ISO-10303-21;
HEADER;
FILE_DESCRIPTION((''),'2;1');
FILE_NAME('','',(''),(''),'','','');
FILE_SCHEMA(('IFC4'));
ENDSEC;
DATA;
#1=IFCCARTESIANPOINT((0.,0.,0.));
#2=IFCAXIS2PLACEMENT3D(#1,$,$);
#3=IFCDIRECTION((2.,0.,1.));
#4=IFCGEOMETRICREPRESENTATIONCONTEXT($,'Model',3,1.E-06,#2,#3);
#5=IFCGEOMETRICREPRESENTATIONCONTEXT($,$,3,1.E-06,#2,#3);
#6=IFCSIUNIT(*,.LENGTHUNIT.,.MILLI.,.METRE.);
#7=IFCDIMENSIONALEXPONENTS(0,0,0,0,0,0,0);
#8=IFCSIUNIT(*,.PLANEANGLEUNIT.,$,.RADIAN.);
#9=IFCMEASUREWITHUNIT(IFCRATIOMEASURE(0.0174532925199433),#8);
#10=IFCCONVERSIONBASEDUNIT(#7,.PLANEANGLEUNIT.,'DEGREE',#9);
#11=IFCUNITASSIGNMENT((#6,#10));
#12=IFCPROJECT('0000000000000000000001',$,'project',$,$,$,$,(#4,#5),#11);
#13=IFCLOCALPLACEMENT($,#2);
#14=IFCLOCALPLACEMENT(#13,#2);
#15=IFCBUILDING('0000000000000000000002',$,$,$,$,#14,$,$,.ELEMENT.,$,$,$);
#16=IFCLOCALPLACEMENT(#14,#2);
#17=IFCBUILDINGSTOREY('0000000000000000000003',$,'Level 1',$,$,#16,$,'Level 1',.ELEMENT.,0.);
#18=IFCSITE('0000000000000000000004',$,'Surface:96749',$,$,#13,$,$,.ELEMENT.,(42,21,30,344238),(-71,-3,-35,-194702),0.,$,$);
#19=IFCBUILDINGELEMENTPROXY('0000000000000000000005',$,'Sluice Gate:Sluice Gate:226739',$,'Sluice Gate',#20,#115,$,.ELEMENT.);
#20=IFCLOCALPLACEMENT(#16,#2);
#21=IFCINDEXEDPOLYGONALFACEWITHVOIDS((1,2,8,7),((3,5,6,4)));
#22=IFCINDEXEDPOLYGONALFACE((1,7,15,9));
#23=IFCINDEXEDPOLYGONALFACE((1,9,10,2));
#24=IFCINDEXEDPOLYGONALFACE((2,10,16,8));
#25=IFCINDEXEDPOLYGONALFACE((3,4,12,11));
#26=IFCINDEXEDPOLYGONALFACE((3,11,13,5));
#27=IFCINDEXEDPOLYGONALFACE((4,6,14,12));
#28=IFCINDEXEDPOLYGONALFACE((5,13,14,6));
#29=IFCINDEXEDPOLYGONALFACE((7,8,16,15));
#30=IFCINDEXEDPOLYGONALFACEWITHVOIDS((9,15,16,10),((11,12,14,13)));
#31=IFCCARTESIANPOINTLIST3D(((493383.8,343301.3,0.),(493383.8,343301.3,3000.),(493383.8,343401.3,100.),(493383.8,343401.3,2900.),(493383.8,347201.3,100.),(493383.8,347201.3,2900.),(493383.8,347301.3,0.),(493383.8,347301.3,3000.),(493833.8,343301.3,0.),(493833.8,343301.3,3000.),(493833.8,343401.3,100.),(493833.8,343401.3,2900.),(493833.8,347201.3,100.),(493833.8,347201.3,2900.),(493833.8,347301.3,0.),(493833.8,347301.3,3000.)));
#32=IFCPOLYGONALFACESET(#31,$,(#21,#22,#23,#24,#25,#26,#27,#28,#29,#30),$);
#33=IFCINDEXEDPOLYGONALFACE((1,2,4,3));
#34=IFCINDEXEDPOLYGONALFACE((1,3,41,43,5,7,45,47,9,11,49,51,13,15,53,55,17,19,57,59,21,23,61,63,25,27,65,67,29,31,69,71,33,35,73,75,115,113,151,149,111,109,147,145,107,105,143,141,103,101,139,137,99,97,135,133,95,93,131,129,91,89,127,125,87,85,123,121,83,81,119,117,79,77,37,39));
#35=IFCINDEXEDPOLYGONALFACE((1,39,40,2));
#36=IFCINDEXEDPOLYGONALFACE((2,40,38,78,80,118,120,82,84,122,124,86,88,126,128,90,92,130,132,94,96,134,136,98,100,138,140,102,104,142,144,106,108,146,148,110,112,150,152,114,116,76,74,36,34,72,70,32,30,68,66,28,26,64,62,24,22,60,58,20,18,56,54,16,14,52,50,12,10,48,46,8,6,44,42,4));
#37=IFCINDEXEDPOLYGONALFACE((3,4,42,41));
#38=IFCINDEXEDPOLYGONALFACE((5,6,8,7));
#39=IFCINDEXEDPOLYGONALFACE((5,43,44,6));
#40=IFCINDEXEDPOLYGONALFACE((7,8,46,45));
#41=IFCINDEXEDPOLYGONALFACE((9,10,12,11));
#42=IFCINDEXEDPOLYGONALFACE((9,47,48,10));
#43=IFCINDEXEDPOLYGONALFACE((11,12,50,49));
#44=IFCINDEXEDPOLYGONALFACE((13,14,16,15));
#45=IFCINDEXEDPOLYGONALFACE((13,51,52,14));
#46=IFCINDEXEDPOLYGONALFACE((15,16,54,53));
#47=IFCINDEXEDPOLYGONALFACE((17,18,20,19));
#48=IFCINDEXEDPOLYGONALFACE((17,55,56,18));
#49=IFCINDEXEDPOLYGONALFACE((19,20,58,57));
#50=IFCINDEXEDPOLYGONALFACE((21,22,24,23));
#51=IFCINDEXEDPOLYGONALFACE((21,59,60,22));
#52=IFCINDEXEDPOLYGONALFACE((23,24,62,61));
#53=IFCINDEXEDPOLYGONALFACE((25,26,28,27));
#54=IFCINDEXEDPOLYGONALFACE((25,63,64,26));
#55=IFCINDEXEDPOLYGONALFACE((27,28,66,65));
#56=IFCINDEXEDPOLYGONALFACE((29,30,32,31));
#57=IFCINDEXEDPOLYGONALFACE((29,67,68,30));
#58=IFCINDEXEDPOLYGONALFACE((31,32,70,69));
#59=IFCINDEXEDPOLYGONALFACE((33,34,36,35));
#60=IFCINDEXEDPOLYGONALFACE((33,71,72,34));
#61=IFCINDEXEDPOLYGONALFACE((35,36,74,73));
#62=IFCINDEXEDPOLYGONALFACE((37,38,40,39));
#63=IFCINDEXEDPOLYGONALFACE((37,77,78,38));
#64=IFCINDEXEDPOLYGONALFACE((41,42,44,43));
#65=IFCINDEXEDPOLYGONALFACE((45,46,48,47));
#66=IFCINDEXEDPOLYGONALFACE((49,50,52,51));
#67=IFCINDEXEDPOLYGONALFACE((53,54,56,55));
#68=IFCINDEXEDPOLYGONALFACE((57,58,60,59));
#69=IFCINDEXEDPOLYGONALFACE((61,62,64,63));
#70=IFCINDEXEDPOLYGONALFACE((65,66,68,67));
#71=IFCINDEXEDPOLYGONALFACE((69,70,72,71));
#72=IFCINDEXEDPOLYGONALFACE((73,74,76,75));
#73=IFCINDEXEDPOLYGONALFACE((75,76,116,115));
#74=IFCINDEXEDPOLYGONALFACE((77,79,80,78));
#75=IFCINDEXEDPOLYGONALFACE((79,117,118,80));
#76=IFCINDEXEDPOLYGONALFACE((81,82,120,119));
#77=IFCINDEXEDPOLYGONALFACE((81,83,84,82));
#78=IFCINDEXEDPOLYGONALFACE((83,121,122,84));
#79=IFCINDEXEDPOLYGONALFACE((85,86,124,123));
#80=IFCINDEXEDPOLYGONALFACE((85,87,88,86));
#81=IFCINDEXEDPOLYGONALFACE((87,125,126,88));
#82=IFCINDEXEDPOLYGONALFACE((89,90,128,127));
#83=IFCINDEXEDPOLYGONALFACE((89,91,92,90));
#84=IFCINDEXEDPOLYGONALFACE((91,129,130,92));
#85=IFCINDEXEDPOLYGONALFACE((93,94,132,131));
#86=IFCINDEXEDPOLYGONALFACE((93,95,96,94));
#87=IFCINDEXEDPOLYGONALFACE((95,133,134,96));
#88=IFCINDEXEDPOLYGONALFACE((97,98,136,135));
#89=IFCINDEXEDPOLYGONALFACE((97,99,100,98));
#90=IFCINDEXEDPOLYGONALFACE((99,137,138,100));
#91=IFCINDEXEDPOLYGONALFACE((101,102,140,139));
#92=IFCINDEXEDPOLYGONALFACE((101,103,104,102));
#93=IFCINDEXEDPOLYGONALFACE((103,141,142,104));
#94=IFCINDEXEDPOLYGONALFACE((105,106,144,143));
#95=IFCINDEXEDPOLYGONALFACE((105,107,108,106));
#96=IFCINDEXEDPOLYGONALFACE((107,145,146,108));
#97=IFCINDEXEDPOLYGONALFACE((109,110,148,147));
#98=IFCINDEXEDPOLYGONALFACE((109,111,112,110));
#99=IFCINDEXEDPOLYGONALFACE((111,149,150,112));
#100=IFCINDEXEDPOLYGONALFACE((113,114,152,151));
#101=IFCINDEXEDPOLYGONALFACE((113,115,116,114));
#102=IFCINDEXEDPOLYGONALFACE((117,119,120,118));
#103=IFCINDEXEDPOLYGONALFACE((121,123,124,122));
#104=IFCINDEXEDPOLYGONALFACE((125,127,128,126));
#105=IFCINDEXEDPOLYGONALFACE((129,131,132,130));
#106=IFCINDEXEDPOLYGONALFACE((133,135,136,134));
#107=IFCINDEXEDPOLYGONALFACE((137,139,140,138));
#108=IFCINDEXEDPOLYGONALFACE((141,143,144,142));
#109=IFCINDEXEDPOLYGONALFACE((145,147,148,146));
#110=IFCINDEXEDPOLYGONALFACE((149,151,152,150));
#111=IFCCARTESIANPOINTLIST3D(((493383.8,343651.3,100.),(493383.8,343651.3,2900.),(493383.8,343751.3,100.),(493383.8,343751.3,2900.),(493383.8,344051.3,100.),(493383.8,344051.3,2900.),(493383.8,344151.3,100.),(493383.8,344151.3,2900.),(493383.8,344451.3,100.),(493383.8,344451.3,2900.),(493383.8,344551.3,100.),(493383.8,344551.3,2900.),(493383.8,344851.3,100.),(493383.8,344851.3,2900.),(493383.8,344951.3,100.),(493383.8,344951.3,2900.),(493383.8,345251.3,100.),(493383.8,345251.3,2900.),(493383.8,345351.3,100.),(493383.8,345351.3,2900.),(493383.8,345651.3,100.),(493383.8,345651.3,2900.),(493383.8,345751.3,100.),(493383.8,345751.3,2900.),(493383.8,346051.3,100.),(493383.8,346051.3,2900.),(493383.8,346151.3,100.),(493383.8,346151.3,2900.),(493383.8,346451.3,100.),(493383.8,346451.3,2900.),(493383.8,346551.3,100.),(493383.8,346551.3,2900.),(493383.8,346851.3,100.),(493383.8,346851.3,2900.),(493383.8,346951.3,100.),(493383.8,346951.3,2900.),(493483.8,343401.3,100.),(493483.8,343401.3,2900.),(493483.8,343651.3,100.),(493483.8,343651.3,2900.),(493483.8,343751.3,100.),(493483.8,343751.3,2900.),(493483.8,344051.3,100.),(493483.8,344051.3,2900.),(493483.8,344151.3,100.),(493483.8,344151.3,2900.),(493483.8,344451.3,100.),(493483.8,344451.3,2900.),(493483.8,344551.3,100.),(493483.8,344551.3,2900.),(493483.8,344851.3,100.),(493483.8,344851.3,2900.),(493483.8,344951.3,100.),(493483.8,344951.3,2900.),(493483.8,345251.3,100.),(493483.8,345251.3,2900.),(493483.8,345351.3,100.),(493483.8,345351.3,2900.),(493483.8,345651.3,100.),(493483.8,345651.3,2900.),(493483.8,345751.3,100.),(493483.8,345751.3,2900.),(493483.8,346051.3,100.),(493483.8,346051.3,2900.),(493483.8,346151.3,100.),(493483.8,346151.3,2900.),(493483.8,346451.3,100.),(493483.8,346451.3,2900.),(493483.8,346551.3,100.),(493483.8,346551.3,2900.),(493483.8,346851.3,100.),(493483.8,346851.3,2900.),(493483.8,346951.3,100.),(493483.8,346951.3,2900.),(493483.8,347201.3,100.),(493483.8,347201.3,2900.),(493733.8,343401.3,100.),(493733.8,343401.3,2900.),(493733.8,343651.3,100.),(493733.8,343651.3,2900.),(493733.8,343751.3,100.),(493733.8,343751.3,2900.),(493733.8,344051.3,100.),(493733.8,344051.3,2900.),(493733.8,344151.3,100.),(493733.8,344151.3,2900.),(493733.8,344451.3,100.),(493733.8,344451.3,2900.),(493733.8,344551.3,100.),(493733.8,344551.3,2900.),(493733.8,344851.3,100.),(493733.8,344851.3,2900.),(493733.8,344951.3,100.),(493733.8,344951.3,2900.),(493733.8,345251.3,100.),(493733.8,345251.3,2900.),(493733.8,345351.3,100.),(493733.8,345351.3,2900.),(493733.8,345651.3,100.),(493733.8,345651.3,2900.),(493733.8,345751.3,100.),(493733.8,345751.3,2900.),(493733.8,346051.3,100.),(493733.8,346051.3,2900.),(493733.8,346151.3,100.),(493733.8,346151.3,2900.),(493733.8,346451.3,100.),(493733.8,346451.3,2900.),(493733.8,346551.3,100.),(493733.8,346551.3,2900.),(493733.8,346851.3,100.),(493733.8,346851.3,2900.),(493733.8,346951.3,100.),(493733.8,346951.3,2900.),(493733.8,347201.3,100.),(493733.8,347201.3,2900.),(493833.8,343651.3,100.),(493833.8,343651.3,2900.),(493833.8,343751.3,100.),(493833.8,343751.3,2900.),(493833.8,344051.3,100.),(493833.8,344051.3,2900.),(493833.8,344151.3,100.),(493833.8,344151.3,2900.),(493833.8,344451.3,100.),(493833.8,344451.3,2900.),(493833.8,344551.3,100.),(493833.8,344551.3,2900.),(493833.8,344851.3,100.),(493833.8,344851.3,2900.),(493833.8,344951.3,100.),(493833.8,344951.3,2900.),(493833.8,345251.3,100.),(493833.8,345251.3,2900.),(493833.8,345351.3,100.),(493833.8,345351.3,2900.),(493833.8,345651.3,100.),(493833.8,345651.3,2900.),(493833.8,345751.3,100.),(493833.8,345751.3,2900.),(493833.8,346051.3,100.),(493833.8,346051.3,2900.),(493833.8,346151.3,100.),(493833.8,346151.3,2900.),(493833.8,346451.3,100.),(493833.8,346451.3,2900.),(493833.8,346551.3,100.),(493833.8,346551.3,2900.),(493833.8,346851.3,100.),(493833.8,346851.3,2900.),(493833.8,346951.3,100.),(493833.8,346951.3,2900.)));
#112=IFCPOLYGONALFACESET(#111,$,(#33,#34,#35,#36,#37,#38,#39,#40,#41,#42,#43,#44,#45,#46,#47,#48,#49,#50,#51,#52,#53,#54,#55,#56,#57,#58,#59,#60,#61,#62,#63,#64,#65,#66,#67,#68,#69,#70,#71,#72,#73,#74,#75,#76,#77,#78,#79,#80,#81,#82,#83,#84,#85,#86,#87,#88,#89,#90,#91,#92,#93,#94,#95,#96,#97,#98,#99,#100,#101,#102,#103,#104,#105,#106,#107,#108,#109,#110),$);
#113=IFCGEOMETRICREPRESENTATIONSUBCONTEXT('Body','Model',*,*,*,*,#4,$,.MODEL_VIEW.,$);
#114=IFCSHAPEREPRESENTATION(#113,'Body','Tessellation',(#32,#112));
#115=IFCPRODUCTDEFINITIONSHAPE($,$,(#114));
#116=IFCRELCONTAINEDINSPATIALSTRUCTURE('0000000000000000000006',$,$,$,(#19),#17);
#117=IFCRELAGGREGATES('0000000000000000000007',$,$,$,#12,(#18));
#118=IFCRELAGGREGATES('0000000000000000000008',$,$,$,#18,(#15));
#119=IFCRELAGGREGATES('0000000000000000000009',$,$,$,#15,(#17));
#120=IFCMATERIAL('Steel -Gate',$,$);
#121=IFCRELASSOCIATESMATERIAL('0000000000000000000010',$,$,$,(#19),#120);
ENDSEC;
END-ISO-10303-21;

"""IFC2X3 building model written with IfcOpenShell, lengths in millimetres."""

from ifc_helpers import new_model, entity, si_unit, converted_unit, direction, frame, origin, place, context, subcontext, project, spatial, polyline, outline, extrude, source, transform, mapped, material, element, save


model = new_model("IFC2X3")

# Units and contexts
model_context = context("Model", 3, precision=1e-06, world=origin(), true_north=direction((2.0, 0.0, 1.0)))
context_of_model = context(None, 3, precision=1e-06, world=origin(), true_north=direction((2.0, 0.0, 1.0)))
body_context = subcontext(model_context, "Body", "Model", "MODEL_VIEW")
ifc_project = project(units=[si_unit("LENGTHUNIT", "METRE", prefix="MILLI"), converted_unit("PLANEANGLEUNIT", "DEGREE", entity("IfcRatioMeasure", 0.0174532925199433), si_unit("PLANEANGLEUNIT", "RADIAN"), dimensions=[0, 0, 0, 0, 0, 0, 0])], contexts=[model_context, context_of_model])

# Site, building, storey
site_placement = place(None, origin())
site = spatial("IfcSite", under=ifc_project, at=site_placement, Name="Surface:96749", CompositionType="ELEMENT", RefLatitude=(42, 21, 30, 344238), RefLongitude=(-71, -3, -35, -194702), RefElevation=0.0)
building_placement = place(site_placement, origin())
building = spatial("IfcBuilding", under=site, at=building_placement, CompositionType="ELEMENT")
storey_placement = place(building_placement, origin())
storey = spatial("IfcBuildingStorey", under=building, at=storey_placement, Name="Level 1", LongName="Level 1", CompositionType="ELEMENT", Elevation=0.0)

# Building element proxy
ifc_material = material(Name="Steel -Gate")
shared_shape_1 = source(origin(), body_context, "Body", "SweptSolid", [
    extrude(outline(polyline([(-2000.0, -1500.0), (2000.0, -1500.0), (2000.0, 1500.0), (-2000.0, 1500.0), (-2000.0, -1500.0)]), holes=[polyline([(-1900.0, 1400.0), (1900.0, 1400.0), (1900.0, -1400.0), (-1900.0, -1400.0), (-1900.0, 1400.0)])]), frame((0.0, -225.0, 1500.0), z_axis=(0.0, 1.0, 0.0), x_axis=(-1.0, 0.0, 0.0)), (0.0, 0.0, 1.0), 450.0),
    extrude(outline(polyline([(125.0, -1650.0), (225.0, -1650.0), (225.0, -1550.0), (125.0, -1550.0), (125.0, -1250.0), (225.0, -1250.0), (225.0, -1150.0), (125.0, -1150.0), (125.0, -850.0), (225.0, -850.0), (225.0, -750.0), (125.0, -750.0), (125.0, -450.0), (225.0, -450.0), (225.0, -350.0), (125.0, -350.0), (125.0, -50.0), (225.0, -50.0), (225.0, 50.0), (125.0, 50.0), (125.0, 350.0), (225.0, 350.0), (225.0, 450.0), (125.0, 450.0), (125.0, 750.0), (225.0, 750.0), (225.0, 850.0), (125.0, 850.0), (125.0, 1150.0), (225.0, 1150.0), (225.0, 1250.0), (125.0, 1250.0), (125.0, 1550.0), (225.0, 1550.0), (225.0, 1650.0), (125.0, 1650.0), (125.0, 1900.0), (-125.0, 1900.0), (-125.0, 1650.0), (-225.0, 1650.0), (-225.0, 1550.0), (-125.0, 1550.0), (-125.0, 1250.0), (-225.0, 1250.0), (-225.0, 1150.0), (-125.0, 1150.0), (-125.0, 850.0), (-225.0, 850.0), (-225.0, 750.0), (-125.0, 750.0), (-125.0, 450.0), (-225.0, 450.0), (-225.0, 350.0), (-125.0, 350.0), (-125.0, 50.0), (-225.0, 50.0), (-225.0, -50.0), (-125.0, -50.0), (-125.0, -350.0), (-225.0, -350.0), (-225.0, -450.0), (-125.0, -450.0), (-125.0, -750.0), (-225.0, -750.0), (-225.0, -850.0), (-125.0, -850.0), (-125.0, -1150.0), (-225.0, -1150.0), (-225.0, -1250.0), (-125.0, -1250.0), (-125.0, -1550.0), (-225.0, -1550.0), (-225.0, -1650.0), (-125.0, -1650.0), (-125.0, -1900.0), (125.0, -1900.0), (125.0, -1650.0)])), frame((0.0, 0.0, 100.0), z_axis=(0.0, 0.0, 1.0), x_axis=(0.0, -1.0, 0.0)), (0.0, 0.0, 1.0), 2800.0),
])
for number, where, z_axis, x_axis, name in (
    (1, (493608.8, 345301.3, 0.0), (0.0, 0.0, 1.0), (0.0, 1.0, 0.0), "Sluice Gate:Sluice Gate:226739"),
):
    element("IfcBuildingElementProxy", number, at=place(storey_placement, frame(where, z_axis=z_axis, x_axis=x_axis)), inside=storey, material=ifc_material, Name=name, ObjectType="Sluice Gate", CompositionType="ELEMENT", context=body_context, shape_type="MappedRepresentation", body=[
        mapped(shared_shape_1, transform((0.0, 0.0, 0.0), scale=1.0)),
    ])

save(model, "model.ifc")
